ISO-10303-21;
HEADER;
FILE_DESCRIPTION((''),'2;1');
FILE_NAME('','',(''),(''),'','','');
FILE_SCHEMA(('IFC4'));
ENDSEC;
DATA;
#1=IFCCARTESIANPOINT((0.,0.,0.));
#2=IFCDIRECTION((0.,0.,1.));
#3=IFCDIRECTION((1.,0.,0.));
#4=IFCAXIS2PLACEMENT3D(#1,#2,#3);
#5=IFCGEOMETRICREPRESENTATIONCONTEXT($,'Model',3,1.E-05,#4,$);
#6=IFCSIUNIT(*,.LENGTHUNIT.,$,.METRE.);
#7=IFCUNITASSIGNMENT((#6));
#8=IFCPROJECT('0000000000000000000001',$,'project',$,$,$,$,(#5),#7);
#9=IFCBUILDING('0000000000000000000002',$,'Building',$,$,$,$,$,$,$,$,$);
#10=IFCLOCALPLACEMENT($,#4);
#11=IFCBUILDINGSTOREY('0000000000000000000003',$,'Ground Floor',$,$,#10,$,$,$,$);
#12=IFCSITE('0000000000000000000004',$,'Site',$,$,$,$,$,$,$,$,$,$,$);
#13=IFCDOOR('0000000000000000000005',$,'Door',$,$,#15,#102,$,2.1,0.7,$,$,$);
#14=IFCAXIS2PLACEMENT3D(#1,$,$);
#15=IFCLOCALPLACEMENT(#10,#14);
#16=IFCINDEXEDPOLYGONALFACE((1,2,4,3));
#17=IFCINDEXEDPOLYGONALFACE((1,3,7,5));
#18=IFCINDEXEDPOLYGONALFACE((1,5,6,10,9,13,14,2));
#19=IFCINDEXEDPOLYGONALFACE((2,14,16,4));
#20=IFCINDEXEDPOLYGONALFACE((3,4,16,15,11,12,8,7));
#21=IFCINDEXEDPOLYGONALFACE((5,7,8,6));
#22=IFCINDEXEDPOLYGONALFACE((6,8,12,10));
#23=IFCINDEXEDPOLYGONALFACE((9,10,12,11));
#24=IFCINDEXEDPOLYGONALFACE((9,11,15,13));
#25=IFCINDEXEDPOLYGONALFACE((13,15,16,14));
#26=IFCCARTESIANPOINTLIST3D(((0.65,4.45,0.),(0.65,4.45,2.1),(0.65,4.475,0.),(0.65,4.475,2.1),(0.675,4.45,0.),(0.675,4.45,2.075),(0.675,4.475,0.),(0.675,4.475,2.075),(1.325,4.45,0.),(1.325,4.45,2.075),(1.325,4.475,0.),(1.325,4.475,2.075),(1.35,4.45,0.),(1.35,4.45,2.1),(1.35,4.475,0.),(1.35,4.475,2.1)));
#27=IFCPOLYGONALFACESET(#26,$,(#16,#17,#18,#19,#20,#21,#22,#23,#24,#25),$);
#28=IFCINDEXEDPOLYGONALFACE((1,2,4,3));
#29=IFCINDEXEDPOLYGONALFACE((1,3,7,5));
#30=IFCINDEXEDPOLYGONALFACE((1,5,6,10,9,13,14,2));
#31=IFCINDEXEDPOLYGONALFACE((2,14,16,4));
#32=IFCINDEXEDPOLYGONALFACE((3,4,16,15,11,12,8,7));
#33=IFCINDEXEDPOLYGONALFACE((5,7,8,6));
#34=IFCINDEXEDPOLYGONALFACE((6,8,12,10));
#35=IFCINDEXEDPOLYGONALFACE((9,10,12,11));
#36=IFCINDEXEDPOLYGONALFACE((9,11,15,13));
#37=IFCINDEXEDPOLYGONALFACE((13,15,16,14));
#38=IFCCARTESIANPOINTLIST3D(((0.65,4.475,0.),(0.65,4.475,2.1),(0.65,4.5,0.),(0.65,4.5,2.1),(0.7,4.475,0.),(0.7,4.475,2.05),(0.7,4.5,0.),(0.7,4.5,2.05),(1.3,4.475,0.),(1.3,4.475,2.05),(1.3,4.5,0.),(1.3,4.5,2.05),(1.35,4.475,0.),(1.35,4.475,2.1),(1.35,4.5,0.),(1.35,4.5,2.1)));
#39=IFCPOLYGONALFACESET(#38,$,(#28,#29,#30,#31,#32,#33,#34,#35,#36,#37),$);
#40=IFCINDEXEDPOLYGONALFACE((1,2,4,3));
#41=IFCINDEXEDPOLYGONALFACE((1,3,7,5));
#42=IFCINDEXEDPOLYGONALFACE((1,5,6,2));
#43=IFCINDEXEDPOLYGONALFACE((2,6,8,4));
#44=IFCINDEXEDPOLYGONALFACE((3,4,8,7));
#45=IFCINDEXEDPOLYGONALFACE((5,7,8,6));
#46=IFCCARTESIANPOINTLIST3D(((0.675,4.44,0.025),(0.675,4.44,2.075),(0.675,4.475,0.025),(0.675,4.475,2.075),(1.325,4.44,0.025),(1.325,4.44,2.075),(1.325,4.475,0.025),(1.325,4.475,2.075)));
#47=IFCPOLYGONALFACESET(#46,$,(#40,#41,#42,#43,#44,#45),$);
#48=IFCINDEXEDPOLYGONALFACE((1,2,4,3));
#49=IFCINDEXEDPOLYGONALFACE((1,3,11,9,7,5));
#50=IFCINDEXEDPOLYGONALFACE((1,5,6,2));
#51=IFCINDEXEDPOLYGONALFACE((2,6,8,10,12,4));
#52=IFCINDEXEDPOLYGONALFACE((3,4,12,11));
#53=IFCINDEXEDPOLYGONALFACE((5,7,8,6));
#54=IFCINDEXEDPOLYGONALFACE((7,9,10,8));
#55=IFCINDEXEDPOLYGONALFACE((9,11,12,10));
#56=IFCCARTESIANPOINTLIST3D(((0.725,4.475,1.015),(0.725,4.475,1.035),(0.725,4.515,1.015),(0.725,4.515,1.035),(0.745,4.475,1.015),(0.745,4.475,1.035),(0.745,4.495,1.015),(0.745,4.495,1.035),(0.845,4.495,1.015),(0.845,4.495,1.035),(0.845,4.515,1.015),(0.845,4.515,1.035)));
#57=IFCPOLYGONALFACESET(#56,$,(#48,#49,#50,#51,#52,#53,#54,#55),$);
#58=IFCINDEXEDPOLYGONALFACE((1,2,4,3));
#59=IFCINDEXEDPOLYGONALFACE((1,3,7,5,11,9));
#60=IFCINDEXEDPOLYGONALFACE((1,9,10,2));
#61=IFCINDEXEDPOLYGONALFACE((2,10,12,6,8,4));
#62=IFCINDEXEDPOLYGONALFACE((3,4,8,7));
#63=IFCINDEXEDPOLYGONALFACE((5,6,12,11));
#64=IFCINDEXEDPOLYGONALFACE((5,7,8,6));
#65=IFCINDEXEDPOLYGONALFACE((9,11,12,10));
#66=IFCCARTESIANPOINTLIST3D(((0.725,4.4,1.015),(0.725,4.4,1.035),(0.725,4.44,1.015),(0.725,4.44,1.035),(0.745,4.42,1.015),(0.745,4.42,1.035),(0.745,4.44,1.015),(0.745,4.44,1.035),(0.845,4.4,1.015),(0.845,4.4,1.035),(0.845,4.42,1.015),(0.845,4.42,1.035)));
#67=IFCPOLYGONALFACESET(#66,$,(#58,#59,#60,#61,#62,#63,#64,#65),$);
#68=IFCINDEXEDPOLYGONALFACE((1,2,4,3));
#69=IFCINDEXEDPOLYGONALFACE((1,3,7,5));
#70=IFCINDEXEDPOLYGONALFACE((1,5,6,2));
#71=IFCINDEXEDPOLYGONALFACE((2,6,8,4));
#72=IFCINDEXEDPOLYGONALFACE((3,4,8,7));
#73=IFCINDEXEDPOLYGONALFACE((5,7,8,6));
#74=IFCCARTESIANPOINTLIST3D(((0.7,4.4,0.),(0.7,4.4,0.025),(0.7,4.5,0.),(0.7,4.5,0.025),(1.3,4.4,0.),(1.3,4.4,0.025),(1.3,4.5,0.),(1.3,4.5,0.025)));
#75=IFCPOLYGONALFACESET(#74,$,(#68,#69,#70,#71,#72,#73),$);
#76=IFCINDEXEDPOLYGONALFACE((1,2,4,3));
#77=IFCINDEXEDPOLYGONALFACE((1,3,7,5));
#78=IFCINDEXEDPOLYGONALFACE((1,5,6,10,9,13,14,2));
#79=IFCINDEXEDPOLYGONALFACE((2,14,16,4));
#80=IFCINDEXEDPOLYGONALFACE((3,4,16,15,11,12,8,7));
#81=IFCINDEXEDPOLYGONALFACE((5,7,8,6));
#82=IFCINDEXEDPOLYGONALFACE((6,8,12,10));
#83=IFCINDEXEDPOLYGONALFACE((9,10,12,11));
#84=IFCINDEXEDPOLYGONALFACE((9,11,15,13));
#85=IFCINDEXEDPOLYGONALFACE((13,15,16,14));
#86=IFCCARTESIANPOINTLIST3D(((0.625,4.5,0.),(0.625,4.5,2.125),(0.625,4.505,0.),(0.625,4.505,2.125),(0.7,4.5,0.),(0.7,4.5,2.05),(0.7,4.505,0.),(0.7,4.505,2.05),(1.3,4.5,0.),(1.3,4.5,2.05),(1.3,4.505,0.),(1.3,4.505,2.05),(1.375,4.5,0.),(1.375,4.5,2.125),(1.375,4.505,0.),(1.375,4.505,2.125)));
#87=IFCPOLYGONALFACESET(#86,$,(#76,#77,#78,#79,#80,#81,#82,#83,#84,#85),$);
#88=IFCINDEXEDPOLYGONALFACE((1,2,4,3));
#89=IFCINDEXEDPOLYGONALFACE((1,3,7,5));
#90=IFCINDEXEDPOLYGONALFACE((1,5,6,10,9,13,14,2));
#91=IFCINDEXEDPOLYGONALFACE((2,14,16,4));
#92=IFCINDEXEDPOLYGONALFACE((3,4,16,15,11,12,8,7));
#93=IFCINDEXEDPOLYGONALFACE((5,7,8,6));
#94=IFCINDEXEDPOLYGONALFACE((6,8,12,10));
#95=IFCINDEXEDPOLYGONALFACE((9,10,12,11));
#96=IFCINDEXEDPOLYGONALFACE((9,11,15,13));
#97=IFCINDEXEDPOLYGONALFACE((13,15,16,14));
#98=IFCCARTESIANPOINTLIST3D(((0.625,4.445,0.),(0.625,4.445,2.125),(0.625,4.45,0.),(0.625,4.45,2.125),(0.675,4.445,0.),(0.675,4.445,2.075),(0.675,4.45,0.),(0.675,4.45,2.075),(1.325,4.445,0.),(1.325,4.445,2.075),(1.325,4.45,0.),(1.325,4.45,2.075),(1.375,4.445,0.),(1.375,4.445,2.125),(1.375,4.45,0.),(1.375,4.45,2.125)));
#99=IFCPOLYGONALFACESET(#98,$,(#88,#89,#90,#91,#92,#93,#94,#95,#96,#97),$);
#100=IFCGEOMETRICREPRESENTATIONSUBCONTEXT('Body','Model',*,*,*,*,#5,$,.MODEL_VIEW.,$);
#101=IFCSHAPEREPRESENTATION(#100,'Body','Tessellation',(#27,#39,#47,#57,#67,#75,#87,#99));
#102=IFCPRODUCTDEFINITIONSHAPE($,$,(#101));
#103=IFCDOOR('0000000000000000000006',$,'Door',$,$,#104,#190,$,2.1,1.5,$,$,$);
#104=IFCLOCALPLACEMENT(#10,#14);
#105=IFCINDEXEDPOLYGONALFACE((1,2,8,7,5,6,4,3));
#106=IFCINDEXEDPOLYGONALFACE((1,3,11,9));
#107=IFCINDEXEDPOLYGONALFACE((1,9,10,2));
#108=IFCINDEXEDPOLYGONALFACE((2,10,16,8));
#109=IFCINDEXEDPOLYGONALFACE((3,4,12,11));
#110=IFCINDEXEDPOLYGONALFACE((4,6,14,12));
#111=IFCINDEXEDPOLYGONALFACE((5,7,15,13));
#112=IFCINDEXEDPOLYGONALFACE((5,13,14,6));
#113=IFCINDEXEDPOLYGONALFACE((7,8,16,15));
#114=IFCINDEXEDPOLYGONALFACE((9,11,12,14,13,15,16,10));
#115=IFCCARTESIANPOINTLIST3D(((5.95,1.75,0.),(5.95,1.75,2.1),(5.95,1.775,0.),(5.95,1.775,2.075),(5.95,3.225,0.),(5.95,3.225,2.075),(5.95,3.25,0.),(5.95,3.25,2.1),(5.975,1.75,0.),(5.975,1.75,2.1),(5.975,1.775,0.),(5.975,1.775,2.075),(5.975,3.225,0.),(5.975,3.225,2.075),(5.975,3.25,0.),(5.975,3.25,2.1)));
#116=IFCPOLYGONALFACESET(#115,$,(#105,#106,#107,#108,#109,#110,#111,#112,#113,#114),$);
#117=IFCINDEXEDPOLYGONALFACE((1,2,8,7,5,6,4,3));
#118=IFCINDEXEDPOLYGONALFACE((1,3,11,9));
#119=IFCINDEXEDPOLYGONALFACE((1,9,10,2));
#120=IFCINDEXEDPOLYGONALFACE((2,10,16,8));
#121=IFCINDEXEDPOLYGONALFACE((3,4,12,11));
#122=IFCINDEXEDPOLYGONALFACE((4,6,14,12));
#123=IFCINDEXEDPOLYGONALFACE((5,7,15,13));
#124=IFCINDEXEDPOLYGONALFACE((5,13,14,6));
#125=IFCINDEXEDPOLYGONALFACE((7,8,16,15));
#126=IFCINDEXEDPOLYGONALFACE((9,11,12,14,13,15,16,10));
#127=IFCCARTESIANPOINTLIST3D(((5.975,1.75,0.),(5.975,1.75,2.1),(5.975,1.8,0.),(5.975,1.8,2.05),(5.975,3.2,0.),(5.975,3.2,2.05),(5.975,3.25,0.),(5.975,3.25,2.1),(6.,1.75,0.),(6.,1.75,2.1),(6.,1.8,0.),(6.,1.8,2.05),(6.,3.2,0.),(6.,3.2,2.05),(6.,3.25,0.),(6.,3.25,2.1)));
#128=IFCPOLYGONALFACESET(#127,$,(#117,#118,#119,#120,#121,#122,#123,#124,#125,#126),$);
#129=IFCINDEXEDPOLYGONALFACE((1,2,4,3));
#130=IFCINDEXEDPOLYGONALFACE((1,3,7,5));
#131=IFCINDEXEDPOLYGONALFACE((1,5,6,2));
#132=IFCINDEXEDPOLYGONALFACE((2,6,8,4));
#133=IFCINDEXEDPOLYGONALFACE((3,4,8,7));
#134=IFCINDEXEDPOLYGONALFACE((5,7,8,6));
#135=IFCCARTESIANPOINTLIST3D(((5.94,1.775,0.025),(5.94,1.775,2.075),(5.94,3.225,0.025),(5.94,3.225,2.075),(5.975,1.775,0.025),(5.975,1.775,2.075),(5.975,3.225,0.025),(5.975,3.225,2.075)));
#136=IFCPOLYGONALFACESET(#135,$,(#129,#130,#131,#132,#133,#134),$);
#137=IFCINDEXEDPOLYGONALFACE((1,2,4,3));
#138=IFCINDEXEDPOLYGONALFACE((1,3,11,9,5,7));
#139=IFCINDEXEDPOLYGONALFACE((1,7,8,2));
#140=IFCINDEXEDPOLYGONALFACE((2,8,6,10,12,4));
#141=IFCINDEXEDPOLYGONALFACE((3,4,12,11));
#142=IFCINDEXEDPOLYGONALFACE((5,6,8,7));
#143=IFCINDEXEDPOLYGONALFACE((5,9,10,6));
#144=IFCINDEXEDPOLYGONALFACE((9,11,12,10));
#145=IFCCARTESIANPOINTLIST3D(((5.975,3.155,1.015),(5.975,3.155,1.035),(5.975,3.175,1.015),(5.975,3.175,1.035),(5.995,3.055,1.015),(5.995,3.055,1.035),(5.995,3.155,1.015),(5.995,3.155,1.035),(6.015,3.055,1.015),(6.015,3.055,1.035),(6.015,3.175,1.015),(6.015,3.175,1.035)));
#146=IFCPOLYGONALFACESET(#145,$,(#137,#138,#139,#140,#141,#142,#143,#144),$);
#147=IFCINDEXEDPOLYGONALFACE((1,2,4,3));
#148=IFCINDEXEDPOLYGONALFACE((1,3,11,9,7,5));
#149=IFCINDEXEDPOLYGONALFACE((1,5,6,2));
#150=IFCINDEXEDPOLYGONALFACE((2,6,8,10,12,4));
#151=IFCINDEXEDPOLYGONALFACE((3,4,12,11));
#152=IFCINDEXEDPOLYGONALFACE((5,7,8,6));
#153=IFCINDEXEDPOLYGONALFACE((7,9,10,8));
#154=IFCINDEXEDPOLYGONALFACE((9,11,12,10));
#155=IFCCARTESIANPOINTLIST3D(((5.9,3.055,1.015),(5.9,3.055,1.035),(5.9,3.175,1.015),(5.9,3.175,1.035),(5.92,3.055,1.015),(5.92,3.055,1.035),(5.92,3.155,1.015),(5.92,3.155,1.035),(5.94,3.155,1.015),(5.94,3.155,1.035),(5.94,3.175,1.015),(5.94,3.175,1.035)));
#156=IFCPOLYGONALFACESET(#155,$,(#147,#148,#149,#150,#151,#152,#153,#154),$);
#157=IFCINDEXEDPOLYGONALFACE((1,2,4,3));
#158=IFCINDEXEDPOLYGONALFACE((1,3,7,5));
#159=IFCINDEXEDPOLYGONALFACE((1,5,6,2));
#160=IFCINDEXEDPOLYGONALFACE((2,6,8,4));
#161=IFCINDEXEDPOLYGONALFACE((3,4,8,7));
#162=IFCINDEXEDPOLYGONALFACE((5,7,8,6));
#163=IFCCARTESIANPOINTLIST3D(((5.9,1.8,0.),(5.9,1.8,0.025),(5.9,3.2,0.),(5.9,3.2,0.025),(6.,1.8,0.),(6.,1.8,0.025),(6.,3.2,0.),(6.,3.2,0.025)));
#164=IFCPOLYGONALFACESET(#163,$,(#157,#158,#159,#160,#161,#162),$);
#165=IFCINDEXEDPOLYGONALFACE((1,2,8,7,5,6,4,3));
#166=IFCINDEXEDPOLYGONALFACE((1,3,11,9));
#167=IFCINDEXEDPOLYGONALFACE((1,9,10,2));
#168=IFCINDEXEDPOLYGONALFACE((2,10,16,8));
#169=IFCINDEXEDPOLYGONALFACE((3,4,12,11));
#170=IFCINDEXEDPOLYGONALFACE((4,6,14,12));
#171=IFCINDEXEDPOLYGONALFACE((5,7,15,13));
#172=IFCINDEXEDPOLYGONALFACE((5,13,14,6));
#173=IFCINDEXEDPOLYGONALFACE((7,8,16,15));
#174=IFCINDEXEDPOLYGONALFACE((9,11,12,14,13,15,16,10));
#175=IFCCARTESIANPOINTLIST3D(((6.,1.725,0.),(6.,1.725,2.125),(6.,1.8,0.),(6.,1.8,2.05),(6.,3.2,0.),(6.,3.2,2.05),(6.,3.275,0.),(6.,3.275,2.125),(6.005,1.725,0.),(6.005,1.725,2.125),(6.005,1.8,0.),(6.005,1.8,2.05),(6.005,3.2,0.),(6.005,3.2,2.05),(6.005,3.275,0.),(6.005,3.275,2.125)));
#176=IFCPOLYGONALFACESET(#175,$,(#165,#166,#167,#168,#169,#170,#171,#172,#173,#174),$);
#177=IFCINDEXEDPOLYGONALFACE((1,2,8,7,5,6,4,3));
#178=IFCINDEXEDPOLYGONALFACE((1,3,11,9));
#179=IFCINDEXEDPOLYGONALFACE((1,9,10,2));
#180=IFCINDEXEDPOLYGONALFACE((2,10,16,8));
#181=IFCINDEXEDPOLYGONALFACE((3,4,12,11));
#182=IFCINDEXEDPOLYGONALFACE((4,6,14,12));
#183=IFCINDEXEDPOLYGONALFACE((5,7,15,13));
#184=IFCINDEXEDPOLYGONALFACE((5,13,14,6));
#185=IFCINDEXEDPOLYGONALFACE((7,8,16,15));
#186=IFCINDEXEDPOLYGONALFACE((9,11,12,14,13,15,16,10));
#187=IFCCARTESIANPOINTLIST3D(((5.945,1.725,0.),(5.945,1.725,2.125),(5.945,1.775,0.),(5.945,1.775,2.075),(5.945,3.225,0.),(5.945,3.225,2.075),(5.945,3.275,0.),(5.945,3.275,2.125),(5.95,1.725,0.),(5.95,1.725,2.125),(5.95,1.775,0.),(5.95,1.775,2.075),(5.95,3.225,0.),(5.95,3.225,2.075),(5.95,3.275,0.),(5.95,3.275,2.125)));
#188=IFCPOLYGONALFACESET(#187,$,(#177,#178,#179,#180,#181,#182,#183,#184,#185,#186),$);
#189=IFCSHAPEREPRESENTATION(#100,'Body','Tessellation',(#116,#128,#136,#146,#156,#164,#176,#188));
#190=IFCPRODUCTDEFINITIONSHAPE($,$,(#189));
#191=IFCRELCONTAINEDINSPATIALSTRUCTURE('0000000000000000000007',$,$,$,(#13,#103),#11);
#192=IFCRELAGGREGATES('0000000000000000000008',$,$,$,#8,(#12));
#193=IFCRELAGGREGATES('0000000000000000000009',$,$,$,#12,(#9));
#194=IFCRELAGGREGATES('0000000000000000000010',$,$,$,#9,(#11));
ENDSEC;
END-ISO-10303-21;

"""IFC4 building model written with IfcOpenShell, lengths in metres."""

from ifc_helpers import new_model, si_unit, frame, origin_with_axes, place, context, subcontext, project, spatial, line, indexed_curve, outline, extrude, element, save


model = new_model("IFC4")

# Units and contexts
model_context = context("Model", 3, precision=1e-05, world=origin_with_axes())
body_context = subcontext(model_context, "Body", "Model", "MODEL_VIEW")
ifc_project = project(units=[si_unit("LENGTHUNIT", "METRE")], contexts=[model_context])

# Site, building, storey
site = spatial("IfcSite", under=ifc_project, Name="Site")
building = spatial("IfcBuilding", under=site, Name="Building")
storey_placement = place(None, origin_with_axes())
storey = spatial("IfcBuildingStorey", under=building, at=storey_placement, Name="Ground Floor")

# Doors
door_1_placement = place(storey_placement, frame((1.35, 4.5, 0.0), z_axis=(0.0, 0.0, 1.0), x_axis=(-1.0, 0.0, 0.0)))
element("IfcDoor", 1, at=door_1_placement, inside=storey, Name="Door", OverallHeight=2.1, OverallWidth=0.7, context=body_context, shape_type="SweptSolid", body=[
    extrude(outline(indexed_curve([(0.0, 0.0), (0.0, 2.1), (0.7, 2.1), (0.7, 0.0), (0.675, 0.0), (0.675, 2.075), (0.025, 2.075), (0.025, 0.0)], segments=[line(1, 2, 3, 4, 5, 6, 7, 8, 1)])), frame((0.0, 0.025, 0.0), z_axis=(0.0, -1.0, 0.0), x_axis=(1.0, 0.0, 0.0)), (0.0, 0.0, -1.0), 0.025),
    extrude(outline(indexed_curve([(0.0, 0.0), (0.0, 2.1), (0.7, 2.1), (0.7, 0.0), (0.65, 0.0), (0.65, 2.05), (0.05, 2.05), (0.05, 0.0)], segments=[line(1, 2, 3, 4, 5, 6, 7, 8, 1)])), frame((0.0, 0.0, 0.0), z_axis=(0.0, -1.0, 0.0), x_axis=(1.0, 0.0, 0.0)), (0.0, 0.0, -1.0), 0.025),
    extrude(outline(indexed_curve([(0.0, 0.0), (0.65, 0.0), (0.65, 0.035), (0.0, 0.035)], segments=[line(1, 2, 3, 4, 1)])), frame((0.025, 0.025, 0.025), z_axis=(0.0, 0.0, 1.0), x_axis=(1.0, 0.0, 0.0)), (0.0, 0.0, 1.0), 2.05),
    extrude(outline(indexed_curve([(0.0, 0.0), (0.0, -0.04), (-0.12, -0.04), (-0.12, -0.02), (-0.02, -0.02), (-0.02, 0.0)], segments=[line(1, 2, 3, 4, 5, 6, 1)])), frame((0.625, 0.025, 1.015), z_axis=(0.0, 0.0, 1.0), x_axis=(1.0, 0.0, 0.0)), (0.0, 0.0, 1.0), 0.02),
    extrude(outline(indexed_curve([(0.0, 0.0), (0.0, 0.04), (-0.12, 0.04), (-0.12, 0.02), (-0.02, 0.02), (-0.02, 0.0)], segments=[line(1, 2, 3, 4, 5, 6, 1)])), frame((0.625, 0.06, 1.015), z_axis=(0.0, 0.0, 1.0), x_axis=(1.0, 0.0, 0.0)), (0.0, 0.0, 1.0), 0.02),
    extrude(outline(indexed_curve([(0.0, 0.0), (0.6, 0.0), (0.6, 0.1), (0.0, 0.1)], segments=[line(1, 2, 3, 4, 1)])), frame((0.05, 0.0, 0.0), z_axis=(0.0, 0.0, 1.0), x_axis=(1.0, 0.0, 0.0)), (0.0, 0.0, 1.0), 0.025),
    extrude(outline(indexed_curve([(0.0, 0.0), (0.0, 2.125), (0.75, 2.125), (0.75, 0.0), (0.675, 0.0), (0.675, 2.05), (0.075, 2.05), (0.075, 0.0)], segments=[line(1, 2, 3, 4, 5, 6, 7, 8, 1)])), frame((-0.025, -0.005, 0.0), z_axis=(0.0, -1.0, 0.0), x_axis=(1.0, 0.0, 0.0)), (0.0, 0.0, -1.0), 0.005),
    extrude(outline(indexed_curve([(0.0, 0.0), (0.0, 2.125), (0.75, 2.125), (0.75, 0.0), (0.7, 0.0), (0.7, 2.075), (0.05, 2.075), (0.05, 0.0)], segments=[line(1, 2, 3, 4, 5, 6, 7, 8, 1)])), frame((-0.025, 0.05, 0.0), z_axis=(0.0, -1.0, 0.0), x_axis=(1.0, 0.0, 0.0)), (0.0, 0.0, -1.0), 0.005),
])
door_2_placement = place(storey_placement, frame((6.0, 1.75, 0.0), z_axis=(0.0, 0.0, 1.0), x_axis=(0.0, 1.0, 0.0)))
element("IfcDoor", 2, at=door_2_placement, inside=storey, Name="Door", OverallHeight=2.1, OverallWidth=1.5, context=body_context, shape_type="SweptSolid", body=[
    extrude(outline(indexed_curve([(0.0, 0.0), (0.0, 2.1), (1.5, 2.1), (1.5, 0.0), (1.475, 0.0), (1.475, 2.075), (0.025, 2.075), (0.025, 0.0)], segments=[line(1, 2, 3, 4, 5, 6, 7, 8, 1)])), frame((0.0, 0.025, 0.0), z_axis=(0.0, -1.0, 0.0), x_axis=(1.0, 0.0, 0.0)), (0.0, 0.0, -1.0), 0.025),
    extrude(outline(indexed_curve([(0.0, 0.0), (0.0, 2.1), (1.5, 2.1), (1.5, 0.0), (1.45, 0.0), (1.45, 2.05), (0.05, 2.05), (0.05, 0.0)], segments=[line(1, 2, 3, 4, 5, 6, 7, 8, 1)])), frame((0.0, 0.0, 0.0), z_axis=(0.0, -1.0, 0.0), x_axis=(1.0, 0.0, 0.0)), (0.0, 0.0, -1.0), 0.025),
    extrude(outline(indexed_curve([(0.0, 0.0), (1.45, 0.0), (1.45, 0.035), (0.0, 0.035)], segments=[line(1, 2, 3, 4, 1)])), frame((0.025, 0.025, 0.025), z_axis=(0.0, 0.0, 1.0), x_axis=(1.0, 0.0, 0.0)), (0.0, 0.0, 1.0), 2.05),
    extrude(outline(indexed_curve([(0.0, 0.0), (0.0, -0.04), (-0.12, -0.04), (-0.12, -0.02), (-0.02, -0.02), (-0.02, 0.0)], segments=[line(1, 2, 3, 4, 5, 6, 1)])), frame((1.425, 0.025, 1.015), z_axis=(0.0, 0.0, 1.0), x_axis=(1.0, 0.0, 0.0)), (0.0, 0.0, 1.0), 0.02),
    extrude(outline(indexed_curve([(0.0, 0.0), (0.0, 0.04), (-0.12, 0.04), (-0.12, 0.02), (-0.02, 0.02), (-0.02, 0.0)], segments=[line(1, 2, 3, 4, 5, 6, 1)])), frame((1.425, 0.06, 1.015), z_axis=(0.0, 0.0, 1.0), x_axis=(1.0, 0.0, 0.0)), (0.0, 0.0, 1.0), 0.02),
    extrude(outline(indexed_curve([(0.0, 0.0), (1.4, 0.0), (1.4, 0.1), (0.0, 0.1)], segments=[line(1, 2, 3, 4, 1)])), frame((0.05, 0.0, 0.0), z_axis=(0.0, 0.0, 1.0), x_axis=(1.0, 0.0, 0.0)), (0.0, 0.0, 1.0), 0.025),
    extrude(outline(indexed_curve([(0.0, 0.0), (0.0, 2.125), (1.55, 2.125), (1.55, 0.0), (1.475, 0.0), (1.475, 2.05), (0.075, 2.05), (0.075, 0.0)], segments=[line(1, 2, 3, 4, 5, 6, 7, 8, 1)])), frame((-0.025, -0.005, 0.0), z_axis=(0.0, -1.0, 0.0), x_axis=(1.0, 0.0, 0.0)), (0.0, 0.0, -1.0), 0.005),
    extrude(outline(indexed_curve([(0.0, 0.0), (0.0, 2.125), (1.55, 2.125), (1.55, 0.0), (1.5, 0.0), (1.5, 2.075), (0.05, 2.075), (0.05, 0.0)], segments=[line(1, 2, 3, 4, 5, 6, 7, 8, 1)])), frame((-0.025, 0.05, 0.0), z_axis=(0.0, -1.0, 0.0), x_axis=(1.0, 0.0, 0.0)), (0.0, 0.0, -1.0), 0.005),
])

save(model, "model.ifc")
